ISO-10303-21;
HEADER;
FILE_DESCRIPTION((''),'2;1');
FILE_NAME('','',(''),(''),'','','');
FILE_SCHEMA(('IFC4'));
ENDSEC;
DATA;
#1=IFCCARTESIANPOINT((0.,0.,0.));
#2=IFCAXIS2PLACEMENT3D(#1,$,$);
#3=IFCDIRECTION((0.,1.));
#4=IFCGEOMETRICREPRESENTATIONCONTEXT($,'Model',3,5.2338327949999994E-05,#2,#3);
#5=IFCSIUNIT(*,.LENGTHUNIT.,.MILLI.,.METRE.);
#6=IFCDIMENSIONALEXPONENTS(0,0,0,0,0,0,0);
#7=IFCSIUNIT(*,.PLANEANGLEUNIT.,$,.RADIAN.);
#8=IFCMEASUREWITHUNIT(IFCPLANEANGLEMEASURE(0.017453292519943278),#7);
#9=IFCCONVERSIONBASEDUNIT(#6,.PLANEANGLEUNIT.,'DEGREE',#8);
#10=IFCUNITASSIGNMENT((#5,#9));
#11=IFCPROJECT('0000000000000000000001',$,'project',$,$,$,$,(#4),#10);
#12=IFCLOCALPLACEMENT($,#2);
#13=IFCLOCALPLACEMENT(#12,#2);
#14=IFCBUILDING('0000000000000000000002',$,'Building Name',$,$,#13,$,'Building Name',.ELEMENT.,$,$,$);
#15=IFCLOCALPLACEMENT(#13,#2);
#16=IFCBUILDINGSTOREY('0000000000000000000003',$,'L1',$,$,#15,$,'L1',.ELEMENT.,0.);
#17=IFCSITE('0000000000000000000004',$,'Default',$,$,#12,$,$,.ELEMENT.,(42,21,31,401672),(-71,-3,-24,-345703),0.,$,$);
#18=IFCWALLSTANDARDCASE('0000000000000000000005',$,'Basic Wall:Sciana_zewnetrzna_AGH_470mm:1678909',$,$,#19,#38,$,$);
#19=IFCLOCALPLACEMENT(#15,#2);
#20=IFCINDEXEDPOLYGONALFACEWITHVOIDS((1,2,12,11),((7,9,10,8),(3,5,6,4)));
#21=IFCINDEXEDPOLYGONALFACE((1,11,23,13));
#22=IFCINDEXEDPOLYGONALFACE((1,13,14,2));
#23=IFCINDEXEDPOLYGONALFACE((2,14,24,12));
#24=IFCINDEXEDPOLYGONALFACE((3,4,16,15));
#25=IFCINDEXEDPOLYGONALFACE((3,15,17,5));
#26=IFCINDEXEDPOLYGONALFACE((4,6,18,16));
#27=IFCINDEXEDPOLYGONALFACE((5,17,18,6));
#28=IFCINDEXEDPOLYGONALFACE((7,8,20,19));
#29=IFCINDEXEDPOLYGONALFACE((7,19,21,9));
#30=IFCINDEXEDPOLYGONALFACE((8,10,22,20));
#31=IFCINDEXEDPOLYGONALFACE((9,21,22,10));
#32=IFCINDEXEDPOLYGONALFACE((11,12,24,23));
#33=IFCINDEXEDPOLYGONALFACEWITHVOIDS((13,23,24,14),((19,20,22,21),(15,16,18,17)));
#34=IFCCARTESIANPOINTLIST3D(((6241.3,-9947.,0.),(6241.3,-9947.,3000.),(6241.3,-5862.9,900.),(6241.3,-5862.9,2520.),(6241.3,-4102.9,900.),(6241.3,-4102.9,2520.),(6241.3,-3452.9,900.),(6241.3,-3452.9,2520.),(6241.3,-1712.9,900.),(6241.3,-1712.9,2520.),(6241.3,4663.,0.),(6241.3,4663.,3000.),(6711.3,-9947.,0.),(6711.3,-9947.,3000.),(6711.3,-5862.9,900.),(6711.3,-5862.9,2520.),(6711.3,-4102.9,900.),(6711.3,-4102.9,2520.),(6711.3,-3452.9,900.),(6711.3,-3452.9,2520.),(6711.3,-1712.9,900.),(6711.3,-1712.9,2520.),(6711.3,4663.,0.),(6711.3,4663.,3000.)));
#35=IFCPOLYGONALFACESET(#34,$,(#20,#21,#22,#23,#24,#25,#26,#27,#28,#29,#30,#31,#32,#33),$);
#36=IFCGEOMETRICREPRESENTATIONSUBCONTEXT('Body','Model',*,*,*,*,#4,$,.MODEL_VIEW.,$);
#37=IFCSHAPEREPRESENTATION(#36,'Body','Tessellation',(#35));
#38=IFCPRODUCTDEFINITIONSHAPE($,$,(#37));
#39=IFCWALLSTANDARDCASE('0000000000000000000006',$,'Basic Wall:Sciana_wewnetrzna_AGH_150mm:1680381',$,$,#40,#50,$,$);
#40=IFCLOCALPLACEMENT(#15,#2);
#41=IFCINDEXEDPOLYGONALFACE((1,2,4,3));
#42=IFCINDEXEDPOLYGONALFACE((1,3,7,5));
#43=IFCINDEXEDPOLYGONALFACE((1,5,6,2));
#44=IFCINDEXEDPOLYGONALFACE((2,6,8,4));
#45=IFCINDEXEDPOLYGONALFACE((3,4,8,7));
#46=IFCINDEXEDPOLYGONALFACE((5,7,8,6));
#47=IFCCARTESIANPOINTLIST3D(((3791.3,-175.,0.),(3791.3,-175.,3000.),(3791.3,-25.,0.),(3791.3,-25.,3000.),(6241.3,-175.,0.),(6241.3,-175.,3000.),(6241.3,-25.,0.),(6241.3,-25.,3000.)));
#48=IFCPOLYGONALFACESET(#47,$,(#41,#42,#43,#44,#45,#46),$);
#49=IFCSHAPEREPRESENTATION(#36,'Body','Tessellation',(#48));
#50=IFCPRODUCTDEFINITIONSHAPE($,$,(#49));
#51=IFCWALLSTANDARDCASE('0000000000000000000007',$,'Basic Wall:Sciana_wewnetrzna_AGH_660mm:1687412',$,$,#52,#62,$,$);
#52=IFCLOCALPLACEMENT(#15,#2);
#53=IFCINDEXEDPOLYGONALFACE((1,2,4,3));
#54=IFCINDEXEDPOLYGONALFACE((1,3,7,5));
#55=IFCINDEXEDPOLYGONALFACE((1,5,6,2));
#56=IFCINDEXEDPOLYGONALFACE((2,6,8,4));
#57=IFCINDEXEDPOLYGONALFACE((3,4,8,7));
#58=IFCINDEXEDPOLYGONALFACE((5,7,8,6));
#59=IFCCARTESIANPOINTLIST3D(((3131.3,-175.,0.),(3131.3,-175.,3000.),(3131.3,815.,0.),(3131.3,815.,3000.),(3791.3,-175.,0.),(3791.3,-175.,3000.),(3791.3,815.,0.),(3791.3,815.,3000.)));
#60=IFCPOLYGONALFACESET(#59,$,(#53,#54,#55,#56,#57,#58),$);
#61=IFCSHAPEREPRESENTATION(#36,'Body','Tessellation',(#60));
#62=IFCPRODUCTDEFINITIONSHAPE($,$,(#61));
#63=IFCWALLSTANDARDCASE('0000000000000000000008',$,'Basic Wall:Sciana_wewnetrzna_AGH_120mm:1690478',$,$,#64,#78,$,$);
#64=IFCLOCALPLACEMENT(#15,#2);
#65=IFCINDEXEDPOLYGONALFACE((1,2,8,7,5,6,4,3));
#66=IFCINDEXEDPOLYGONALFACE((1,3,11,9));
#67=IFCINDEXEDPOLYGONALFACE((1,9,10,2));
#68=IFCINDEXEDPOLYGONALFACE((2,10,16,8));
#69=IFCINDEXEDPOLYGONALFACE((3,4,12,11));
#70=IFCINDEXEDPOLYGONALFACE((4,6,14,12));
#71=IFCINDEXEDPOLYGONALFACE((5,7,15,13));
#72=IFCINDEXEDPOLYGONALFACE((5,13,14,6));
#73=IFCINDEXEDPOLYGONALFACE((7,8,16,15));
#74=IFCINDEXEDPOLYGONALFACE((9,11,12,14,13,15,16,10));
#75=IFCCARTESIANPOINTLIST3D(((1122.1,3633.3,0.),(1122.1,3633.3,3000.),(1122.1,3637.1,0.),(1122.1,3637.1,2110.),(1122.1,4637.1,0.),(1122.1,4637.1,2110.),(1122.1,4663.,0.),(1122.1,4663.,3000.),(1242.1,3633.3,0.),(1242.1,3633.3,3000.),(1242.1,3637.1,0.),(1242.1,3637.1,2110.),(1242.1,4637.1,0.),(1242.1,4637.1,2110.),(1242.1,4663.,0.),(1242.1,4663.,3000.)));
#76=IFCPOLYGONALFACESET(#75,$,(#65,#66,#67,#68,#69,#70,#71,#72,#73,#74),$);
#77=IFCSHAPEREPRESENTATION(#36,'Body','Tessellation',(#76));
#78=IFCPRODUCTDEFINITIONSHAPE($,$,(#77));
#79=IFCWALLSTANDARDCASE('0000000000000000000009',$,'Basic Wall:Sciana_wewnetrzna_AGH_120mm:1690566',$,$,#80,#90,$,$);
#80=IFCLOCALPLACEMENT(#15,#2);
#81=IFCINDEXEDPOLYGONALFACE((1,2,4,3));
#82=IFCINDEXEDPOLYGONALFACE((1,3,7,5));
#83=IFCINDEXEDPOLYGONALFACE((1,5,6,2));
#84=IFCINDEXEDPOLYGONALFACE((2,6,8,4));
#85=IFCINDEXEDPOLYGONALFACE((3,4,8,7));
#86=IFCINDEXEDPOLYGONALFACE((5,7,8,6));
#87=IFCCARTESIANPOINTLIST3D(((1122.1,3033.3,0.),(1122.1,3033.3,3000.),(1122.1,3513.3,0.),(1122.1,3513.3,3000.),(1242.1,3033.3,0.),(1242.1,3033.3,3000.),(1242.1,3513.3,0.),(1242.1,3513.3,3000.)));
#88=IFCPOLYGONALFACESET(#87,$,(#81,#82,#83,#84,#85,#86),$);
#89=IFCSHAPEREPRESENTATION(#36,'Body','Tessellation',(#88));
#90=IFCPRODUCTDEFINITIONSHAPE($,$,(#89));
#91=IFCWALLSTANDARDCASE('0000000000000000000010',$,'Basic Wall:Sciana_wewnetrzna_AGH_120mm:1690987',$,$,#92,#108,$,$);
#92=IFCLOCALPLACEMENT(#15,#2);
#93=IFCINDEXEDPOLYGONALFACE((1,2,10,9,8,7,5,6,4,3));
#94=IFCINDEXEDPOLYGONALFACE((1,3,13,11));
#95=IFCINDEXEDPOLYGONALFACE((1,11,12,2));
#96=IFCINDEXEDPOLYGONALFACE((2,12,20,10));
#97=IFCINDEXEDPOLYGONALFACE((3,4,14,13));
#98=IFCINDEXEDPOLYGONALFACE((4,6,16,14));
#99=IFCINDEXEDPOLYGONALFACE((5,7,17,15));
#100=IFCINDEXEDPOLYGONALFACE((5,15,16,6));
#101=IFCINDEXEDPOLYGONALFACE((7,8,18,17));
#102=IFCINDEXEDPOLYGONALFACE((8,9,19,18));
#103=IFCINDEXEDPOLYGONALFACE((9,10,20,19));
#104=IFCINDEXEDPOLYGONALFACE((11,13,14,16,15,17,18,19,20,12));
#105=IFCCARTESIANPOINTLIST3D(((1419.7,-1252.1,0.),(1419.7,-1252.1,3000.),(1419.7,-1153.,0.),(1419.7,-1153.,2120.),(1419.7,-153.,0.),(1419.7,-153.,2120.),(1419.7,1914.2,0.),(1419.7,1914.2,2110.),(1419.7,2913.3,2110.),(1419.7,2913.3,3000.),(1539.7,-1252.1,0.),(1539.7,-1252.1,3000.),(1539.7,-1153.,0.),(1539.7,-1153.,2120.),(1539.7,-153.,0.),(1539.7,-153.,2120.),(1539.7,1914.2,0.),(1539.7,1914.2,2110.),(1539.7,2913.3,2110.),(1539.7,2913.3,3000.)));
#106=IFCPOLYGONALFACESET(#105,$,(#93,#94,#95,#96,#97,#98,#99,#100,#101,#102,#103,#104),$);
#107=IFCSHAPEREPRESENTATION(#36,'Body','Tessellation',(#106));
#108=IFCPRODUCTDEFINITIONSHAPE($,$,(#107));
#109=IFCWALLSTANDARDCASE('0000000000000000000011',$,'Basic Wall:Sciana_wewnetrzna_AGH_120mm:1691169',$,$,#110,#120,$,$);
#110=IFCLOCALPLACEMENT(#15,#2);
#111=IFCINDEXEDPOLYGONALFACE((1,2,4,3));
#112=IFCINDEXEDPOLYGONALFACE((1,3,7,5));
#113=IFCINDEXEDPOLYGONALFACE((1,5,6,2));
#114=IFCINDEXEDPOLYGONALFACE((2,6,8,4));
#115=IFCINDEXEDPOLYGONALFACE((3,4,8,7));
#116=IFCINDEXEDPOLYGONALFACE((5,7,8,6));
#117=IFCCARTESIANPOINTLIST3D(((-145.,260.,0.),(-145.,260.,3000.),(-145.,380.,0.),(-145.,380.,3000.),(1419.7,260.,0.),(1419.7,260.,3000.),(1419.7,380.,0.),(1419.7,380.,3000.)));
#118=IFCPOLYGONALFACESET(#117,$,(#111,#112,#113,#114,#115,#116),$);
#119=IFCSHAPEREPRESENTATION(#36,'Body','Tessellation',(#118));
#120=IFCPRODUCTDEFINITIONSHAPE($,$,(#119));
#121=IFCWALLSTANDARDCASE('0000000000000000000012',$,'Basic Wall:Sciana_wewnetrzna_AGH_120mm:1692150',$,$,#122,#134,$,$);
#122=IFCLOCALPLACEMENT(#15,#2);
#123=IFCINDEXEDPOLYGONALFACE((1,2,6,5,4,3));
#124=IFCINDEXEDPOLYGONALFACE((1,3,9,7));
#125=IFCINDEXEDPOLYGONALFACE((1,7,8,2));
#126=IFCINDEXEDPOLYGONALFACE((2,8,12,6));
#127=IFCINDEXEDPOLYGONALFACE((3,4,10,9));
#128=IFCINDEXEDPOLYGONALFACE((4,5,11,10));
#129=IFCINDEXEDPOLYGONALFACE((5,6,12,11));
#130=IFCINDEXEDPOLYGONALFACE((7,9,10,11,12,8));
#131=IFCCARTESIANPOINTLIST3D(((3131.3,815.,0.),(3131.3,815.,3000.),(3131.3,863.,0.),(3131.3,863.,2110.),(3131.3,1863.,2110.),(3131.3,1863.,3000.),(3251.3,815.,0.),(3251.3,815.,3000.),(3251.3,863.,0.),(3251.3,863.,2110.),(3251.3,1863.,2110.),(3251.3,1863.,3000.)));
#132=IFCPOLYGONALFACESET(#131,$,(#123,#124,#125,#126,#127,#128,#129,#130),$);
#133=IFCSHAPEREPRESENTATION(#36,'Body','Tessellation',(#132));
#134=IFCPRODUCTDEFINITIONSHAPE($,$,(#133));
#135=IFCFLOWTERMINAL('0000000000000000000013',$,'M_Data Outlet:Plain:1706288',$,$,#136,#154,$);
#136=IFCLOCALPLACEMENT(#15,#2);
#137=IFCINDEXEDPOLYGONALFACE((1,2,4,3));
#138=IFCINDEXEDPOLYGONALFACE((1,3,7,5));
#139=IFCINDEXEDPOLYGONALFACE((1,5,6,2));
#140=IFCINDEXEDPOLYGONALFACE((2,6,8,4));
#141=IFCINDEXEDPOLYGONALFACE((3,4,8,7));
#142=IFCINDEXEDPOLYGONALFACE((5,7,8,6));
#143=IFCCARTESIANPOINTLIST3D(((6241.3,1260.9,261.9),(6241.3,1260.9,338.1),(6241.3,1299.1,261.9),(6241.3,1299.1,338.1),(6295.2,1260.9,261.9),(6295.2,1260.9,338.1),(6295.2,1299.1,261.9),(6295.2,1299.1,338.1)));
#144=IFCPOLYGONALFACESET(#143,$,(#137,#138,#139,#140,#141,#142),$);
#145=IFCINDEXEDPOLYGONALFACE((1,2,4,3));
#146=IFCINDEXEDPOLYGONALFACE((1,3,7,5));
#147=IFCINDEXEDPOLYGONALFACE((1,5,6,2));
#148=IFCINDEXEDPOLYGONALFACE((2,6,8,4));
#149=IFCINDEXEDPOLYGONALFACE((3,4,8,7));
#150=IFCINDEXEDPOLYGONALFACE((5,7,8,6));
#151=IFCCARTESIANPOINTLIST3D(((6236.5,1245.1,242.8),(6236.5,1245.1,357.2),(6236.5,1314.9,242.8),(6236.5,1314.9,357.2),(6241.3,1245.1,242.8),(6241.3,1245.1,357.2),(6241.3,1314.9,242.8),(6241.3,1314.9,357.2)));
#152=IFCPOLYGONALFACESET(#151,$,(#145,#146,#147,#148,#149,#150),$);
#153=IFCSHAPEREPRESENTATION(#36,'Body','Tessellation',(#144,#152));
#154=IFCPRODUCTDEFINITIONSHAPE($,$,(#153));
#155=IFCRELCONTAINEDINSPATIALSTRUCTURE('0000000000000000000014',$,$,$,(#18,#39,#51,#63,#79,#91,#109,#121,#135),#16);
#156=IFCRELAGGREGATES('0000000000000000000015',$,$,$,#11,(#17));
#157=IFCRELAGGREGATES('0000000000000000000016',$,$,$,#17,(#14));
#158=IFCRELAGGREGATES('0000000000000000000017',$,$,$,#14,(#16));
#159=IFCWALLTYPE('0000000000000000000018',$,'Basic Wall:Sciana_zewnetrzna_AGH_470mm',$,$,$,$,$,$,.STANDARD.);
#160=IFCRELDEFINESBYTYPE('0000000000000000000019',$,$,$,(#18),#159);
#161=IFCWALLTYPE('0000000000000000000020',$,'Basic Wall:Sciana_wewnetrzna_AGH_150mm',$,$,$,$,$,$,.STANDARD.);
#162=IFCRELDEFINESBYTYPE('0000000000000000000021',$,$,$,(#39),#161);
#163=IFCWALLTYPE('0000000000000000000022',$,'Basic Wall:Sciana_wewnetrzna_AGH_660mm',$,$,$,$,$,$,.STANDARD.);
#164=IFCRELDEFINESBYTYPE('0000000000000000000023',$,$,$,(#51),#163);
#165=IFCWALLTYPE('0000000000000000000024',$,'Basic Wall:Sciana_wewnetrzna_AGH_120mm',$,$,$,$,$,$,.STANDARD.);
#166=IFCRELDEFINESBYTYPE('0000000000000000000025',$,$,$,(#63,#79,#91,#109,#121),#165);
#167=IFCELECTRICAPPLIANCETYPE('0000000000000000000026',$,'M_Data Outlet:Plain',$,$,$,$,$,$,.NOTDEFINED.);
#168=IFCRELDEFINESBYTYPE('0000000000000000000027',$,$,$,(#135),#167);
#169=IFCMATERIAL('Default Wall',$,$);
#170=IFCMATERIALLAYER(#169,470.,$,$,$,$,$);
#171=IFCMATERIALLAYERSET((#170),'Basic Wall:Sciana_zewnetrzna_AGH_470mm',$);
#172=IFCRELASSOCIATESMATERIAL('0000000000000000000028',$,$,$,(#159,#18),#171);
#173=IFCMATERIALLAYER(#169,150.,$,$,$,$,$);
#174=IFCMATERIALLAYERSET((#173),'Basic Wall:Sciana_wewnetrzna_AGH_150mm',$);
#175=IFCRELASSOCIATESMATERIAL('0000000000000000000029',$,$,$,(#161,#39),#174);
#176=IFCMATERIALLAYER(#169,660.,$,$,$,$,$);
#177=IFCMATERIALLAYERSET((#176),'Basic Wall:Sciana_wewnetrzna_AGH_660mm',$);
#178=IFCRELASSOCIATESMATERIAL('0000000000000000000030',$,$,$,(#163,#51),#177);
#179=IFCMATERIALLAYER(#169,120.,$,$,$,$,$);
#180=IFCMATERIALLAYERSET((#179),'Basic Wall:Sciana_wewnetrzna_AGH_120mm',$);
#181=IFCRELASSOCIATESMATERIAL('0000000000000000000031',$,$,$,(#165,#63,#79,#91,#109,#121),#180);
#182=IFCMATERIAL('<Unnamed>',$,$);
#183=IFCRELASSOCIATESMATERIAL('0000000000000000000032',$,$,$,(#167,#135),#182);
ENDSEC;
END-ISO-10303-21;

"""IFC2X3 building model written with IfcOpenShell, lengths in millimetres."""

from ifc_helpers import new_model, entity, si_unit, converted_unit, direction, frame, frame_2d, origin, place, context, subcontext, project, spatial, rectangle, extrude, source, transform, mapped, material, layer, layer_set, layer_usage, type_object, type_shapes, element, save


model = new_model("IFC2X3")

# Units and contexts
model_context = context("Model", 3, precision=5.2338327949999994e-05, world=origin(), true_north=direction((0.0, 1.0)))
body_context = subcontext(model_context, "Body", "Model", "MODEL_VIEW")
ifc_project = project(units=[si_unit("LENGTHUNIT", "METRE", prefix="MILLI"), converted_unit("PLANEANGLEUNIT", "DEGREE", entity("IfcPlaneAngleMeasure", 0.017453292519943278), si_unit("PLANEANGLEUNIT", "RADIAN"), dimensions=[0, 0, 0, 0, 0, 0, 0])], contexts=[model_context])

# Site, building, storey
site_placement = place(None, origin())
site = spatial("IfcSite", under=ifc_project, at=site_placement, Name="Default", CompositionType="ELEMENT", RefLatitude=(42, 21, 31, 401672), RefLongitude=(-71, -3, -24, -345703), RefElevation=0.0)
building_placement = place(site_placement, origin())
building = spatial("IfcBuilding", under=site, at=building_placement, Name="Building Name", LongName="Building Name", CompositionType="ELEMENT")
storey_placement = place(building_placement, origin())
storey = spatial("IfcBuildingStorey", under=building, at=storey_placement, Name="L1", LongName="L1", CompositionType="ELEMENT", Elevation=0.0)

# Wall, openings
ifc_material_1 = material(Name="Default Wall")
ifc_layer_1 = layer(ifc_material_1, 470.0)
ifc_layer_set_1 = layer_set([ifc_layer_1], Name="Basic Wall:Sciana_zewnetrzna_AGH_470mm")
ifc_layer_usage_1 = layer_usage(ifc_layer_set_1, "AXIS2", "NEGATIVE", 235.0)
wall_type_1 = type_object("IfcWallType", Name="Basic Wall:Sciana_zewnetrzna_AGH_470mm", PredefinedType="STANDARD", material=ifc_layer_set_1)
wall_1_placement = place(storey_placement, frame((6476.3, 4663.0, 0.0), z_axis=(0.0, 0.0, 1.0), x_axis=(0.0, -1.0, 0.0)))
wall_1 = element("IfcWallStandardCase", 1, at=wall_1_placement, inside=storey, type_object=wall_type_1, material=ifc_layer_usage_1, Name="Basic Wall:Sciana_zewnetrzna_AGH_470mm:1678909", context=body_context, shape_type="SweptSolid", body=[
    extrude(rectangle(XDim=14610.0, YDim=470.0, at=frame_2d((7305.0, 0.0), x_axis=(-1.0, 0.0))), origin(), (0.0, 0.0, 1.0), 3000.0),
])
opening_1_placement = place(wall_1_placement, frame((8765.9, -235.0, 900.0)))
element("IfcOpeningElement", 2, at=opening_1_placement, cuts=wall_1, ObjectType="Opening", context=body_context, shape_type="SweptSolid", body=[
    extrude(rectangle(XDim=1620.0, YDim=1760.0, at=frame_2d((810.0, 880.0), x_axis=(-1.0, 0.0))), frame((0.0, 0.0, 0.0), z_axis=(0.0, 1.0, 0.0), x_axis=(0.0, 0.0, 1.0)), (0.0, 0.0, 1.0), 470.0),
])
opening_2_placement = place(wall_1_placement, frame((6375.9, -235.0, 900.0)))
element("IfcOpeningElement", 3, at=opening_2_placement, cuts=wall_1, ObjectType="Opening", context=body_context, shape_type="SweptSolid", body=[
    extrude(rectangle(XDim=1620.0, YDim=1740.0, at=frame_2d((810.0, 870.0), x_axis=(-1.0, 0.0))), frame((0.0, 0.0, 0.0), z_axis=(0.0, 1.0, 0.0), x_axis=(0.0, 0.0, 1.0)), (0.0, 0.0, 1.0), 470.0),
])

# Walls
ifc_layer_2 = layer(ifc_material_1, 150.0)
ifc_layer_set_2 = layer_set([ifc_layer_2], Name="Basic Wall:Sciana_wewnetrzna_AGH_150mm")
ifc_layer_usage_2 = layer_usage(ifc_layer_set_2, "AXIS2", "NEGATIVE", 75.0)
wall_type_2 = type_object("IfcWallType", Name="Basic Wall:Sciana_wewnetrzna_AGH_150mm", PredefinedType="STANDARD", material=ifc_layer_set_2)
wall_2_placement = place(storey_placement, frame((6241.3, -100.0, 0.0), z_axis=(0.0, 0.0, 1.0), x_axis=(-1.0, 0.0, 0.0)))
element("IfcWallStandardCase", 4, at=wall_2_placement, inside=storey, type_object=wall_type_2, material=ifc_layer_usage_2, Name="Basic Wall:Sciana_wewnetrzna_AGH_150mm:1680381", context=body_context, shape_type="SweptSolid", body=[
    extrude(rectangle(XDim=2450.0, YDim=150.0, at=frame_2d((1225.0, 0.0), x_axis=(-1.0, 0.0))), origin(), (0.0, 0.0, 1.0), 3000.0),
])
ifc_layer_3 = layer(ifc_material_1, 660.0)
ifc_layer_set_3 = layer_set([ifc_layer_3], Name="Basic Wall:Sciana_wewnetrzna_AGH_660mm")
ifc_layer_usage_3 = layer_usage(ifc_layer_set_3, "AXIS2", "NEGATIVE", 330.0)
wall_type_3 = type_object("IfcWallType", Name="Basic Wall:Sciana_wewnetrzna_AGH_660mm", PredefinedType="STANDARD", material=ifc_layer_set_3)
wall_3_placement = place(storey_placement, frame((3461.3, -175.0, 0.0), z_axis=(0.0, 0.0, 1.0), x_axis=(0.0, 1.0, 0.0)))
element("IfcWallStandardCase", 5, at=wall_3_placement, inside=storey, type_object=wall_type_3, material=ifc_layer_usage_3, Name="Basic Wall:Sciana_wewnetrzna_AGH_660mm:1687412", context=body_context, shape_type="SweptSolid", body=[
    extrude(rectangle(XDim=990.0, YDim=660.0, at=frame_2d((495.0, 0.0), x_axis=(-1.0, 0.0))), origin(), (0.0, 0.0, 1.0), 3000.0),
])

# Wall, opening
ifc_layer_4 = layer(ifc_material_1, 120.0)
ifc_layer_set_4 = layer_set([ifc_layer_4], Name="Basic Wall:Sciana_wewnetrzna_AGH_120mm")
ifc_layer_usage_4 = layer_usage(ifc_layer_set_4, "AXIS2", "NEGATIVE", 60.0)
wall_type_4 = type_object("IfcWallType", Name="Basic Wall:Sciana_wewnetrzna_AGH_120mm", PredefinedType="STANDARD", material=ifc_layer_set_4)
wall_4_placement = place(storey_placement, frame((1182.1, 3633.3, 0.0), z_axis=(0.0, 0.0, 1.0), x_axis=(0.0, 1.0, 0.0)))
wall_4 = element("IfcWallStandardCase", 6, at=wall_4_placement, inside=storey, type_object=wall_type_4, material=ifc_layer_usage_4, Name="Basic Wall:Sciana_wewnetrzna_AGH_120mm:1690478", context=body_context, shape_type="SweptSolid", body=[
    extrude(rectangle(XDim=1029.8, YDim=120.0, at=frame_2d((514.9, 0.0), x_axis=(-1.0, 0.0))), origin(), (0.0, 0.0, 1.0), 3000.0),
])
opening_3_placement = place(wall_4_placement, frame((1003.9, 60.0, 0.0)))
element("IfcOpeningElement", 7, at=opening_3_placement, cuts=wall_4, ObjectType="Opening", context=body_context, shape_type="SweptSolid", body=[
    extrude(rectangle(XDim=2110.0, YDim=1000.0, at=frame_2d((1055.0, 500.0), x_axis=(1.0, 0.0))), frame((0.0, 0.0, 0.0), z_axis=(0.0, -1.0, 0.0), x_axis=(0.0, 0.0, 1.0)), (0.0, 0.0, 1.0), 120.0),
])

# Wall
ifc_layer_usage_5 = layer_usage(ifc_layer_set_4, "AXIS2", "NEGATIVE", 60.0)
wall_5_placement = place(storey_placement, frame((1182.1, 3513.3, 0.0), z_axis=(0.0, 0.0, 1.0), x_axis=(0.0, -1.0, 0.0)))
element("IfcWallStandardCase", 8, at=wall_5_placement, inside=storey, type_object=wall_type_4, material=ifc_layer_usage_5, Name="Basic Wall:Sciana_wewnetrzna_AGH_120mm:1690566", context=body_context, shape_type="SweptSolid", body=[
    extrude(rectangle(XDim=480.0, YDim=120.0, at=frame_2d((240.0, 0.0), x_axis=(-1.0, 0.0))), origin(), (0.0, 0.0, 1.0), 3000.0),
])

# Wall, openings
ifc_layer_usage_6 = layer_usage(ifc_layer_set_4, "AXIS2", "NEGATIVE", 60.0)
wall_6_placement = place(storey_placement, frame((1479.7, -1252.1, 0.0), z_axis=(0.0, 0.0, 1.0), x_axis=(0.0, 1.0, 0.0)))
wall_6 = element("IfcWallStandardCase", 9, at=wall_6_placement, inside=storey, type_object=wall_type_4, material=ifc_layer_usage_6, Name="Basic Wall:Sciana_wewnetrzna_AGH_120mm:1690987", context=body_context, shape_type="SweptSolid", body=[
    extrude(rectangle(XDim=4165.3, YDim=120.0, at=frame_2d((2082.7, 0.0), x_axis=(1.0, 0.0))), origin(), (0.0, 0.0, 1.0), 3000.0),
])
opening_4_placement = place(wall_6_placement, frame((4166.3, 60.0, 0.0)))
element("IfcOpeningElement", 10, at=opening_4_placement, cuts=wall_6, ObjectType="Opening", context=body_context, shape_type="SweptSolid", body=[
    extrude(rectangle(XDim=2110.0, YDim=1000.0, at=frame_2d((1055.0, 500.0), x_axis=(1.0, 0.0))), frame((0.0, 0.0, 0.0), z_axis=(0.0, -1.0, 0.0), x_axis=(0.0, 0.0, 1.0)), (0.0, 0.0, 1.0), 120.0),
])
opening_5_placement = place(wall_6_placement, frame((1099.1, 60.0, 0.0)))
element("IfcOpeningElement", 11, at=opening_5_placement, cuts=wall_6, ObjectType="Opening", context=body_context, shape_type="SweptSolid", body=[
    extrude(rectangle(XDim=2120.0, YDim=1000.0, at=frame_2d((1060.0, 500.0), x_axis=(1.0, 0.0))), frame((0.0, 0.0, 0.0), z_axis=(0.0, -1.0, 0.0), x_axis=(0.0, 0.0, 1.0)), (0.0, 0.0, 1.0), 120.0),
])

# Wall
ifc_layer_usage_7 = layer_usage(ifc_layer_set_4, "AXIS2", "NEGATIVE", 60.0)
wall_7_placement = place(storey_placement, frame((1419.7, 320.0, 0.0), z_axis=(0.0, 0.0, 1.0), x_axis=(-1.0, 0.0, 0.0)))
element("IfcWallStandardCase", 12, at=wall_7_placement, inside=storey, type_object=wall_type_4, material=ifc_layer_usage_7, Name="Basic Wall:Sciana_wewnetrzna_AGH_120mm:1691169", context=body_context, shape_type="SweptSolid", body=[
    extrude(rectangle(XDim=1564.7, YDim=120.0, at=frame_2d((782.3, 0.0), x_axis=(-1.0, 0.0))), origin(), (0.0, 0.0, 1.0), 3000.0),
])

# Wall, opening
ifc_layer_usage_8 = layer_usage(ifc_layer_set_4, "AXIS2", "NEGATIVE", 60.0)
wall_8_placement = place(storey_placement, frame((3191.3, 815.0, 0.0), z_axis=(0.0, 0.0, 1.0), x_axis=(0.0, 1.0, 0.0)))
wall_8 = element("IfcWallStandardCase", 13, at=wall_8_placement, inside=storey, type_object=wall_type_4, material=ifc_layer_usage_8, Name="Basic Wall:Sciana_wewnetrzna_AGH_120mm:1692150", context=body_context, shape_type="SweptSolid", body=[
    extrude(rectangle(XDim=1048.0, YDim=120.0, at=frame_2d((524.0, 0.0), x_axis=(-1.0, 0.0))), origin(), (0.0, 0.0, 1.0), 3000.0),
])
opening_6_placement = place(wall_8_placement, frame((1048.0, 60.0, 0.0)))
element("IfcOpeningElement", 14, at=opening_6_placement, cuts=wall_8, ObjectType="Opening", context=body_context, shape_type="SweptSolid", body=[
    extrude(rectangle(XDim=2110.0, YDim=1000.0, at=frame_2d((1055.0, 500.0), x_axis=(1.0, 0.0))), frame((0.0, 0.0, 0.0), z_axis=(0.0, -1.0, 0.0), x_axis=(0.0, 0.0, 1.0)), (0.0, 0.0, 1.0), 120.0),
])

# Flow terminal
ifc_material_2 = material(Name="<Unnamed>")
electric_appliance_type = type_object("IfcElectricApplianceType", Name="M_Data Outlet:Plain", PredefinedType="NOTDEFINED", material=ifc_material_2)
shared_shape_1 = source(origin(), body_context, "Body", "SweptSolid", [
    extrude(rectangle(XDim=38.1, YDim=76.2, at=frame_2d((0.0, 0.0), x_axis=(1.0, 0.0))), frame((0.0, 0.0, -54.0), z_axis=(0.0, 0.0, 1.0), x_axis=(-1.0, 0.0, 0.0)), (0.0, 0.0, 1.0), 54.0),
    extrude(rectangle(XDim=69.9, YDim=114.3, at=frame_2d((0.0, 0.0), x_axis=(1.0, 0.0))), frame((0.0, 0.0, 0.0), z_axis=(0.0, 0.0, 1.0), x_axis=(-1.0, 0.0, 0.0)), (0.0, 0.0, 1.0), 4.8),
])
type_shapes(electric_appliance_type, [shared_shape_1])
flow_terminal_placement = place(storey_placement, frame((6241.3, 1280.0, 300.0), z_axis=(-1.0, 0.0, 0.0), x_axis=(0.0, -1.0, 0.0)))
element("IfcFlowTerminal", 15, at=flow_terminal_placement, inside=storey, type_object=electric_appliance_type, material=ifc_material_2, Name="M_Data Outlet:Plain:1706288", context=body_context, shape_type="MappedRepresentation", body=[
    mapped(shared_shape_1, transform((0.0, 0.0, 0.0), scale=1.0)),
])

save(model, "model.ifc")
